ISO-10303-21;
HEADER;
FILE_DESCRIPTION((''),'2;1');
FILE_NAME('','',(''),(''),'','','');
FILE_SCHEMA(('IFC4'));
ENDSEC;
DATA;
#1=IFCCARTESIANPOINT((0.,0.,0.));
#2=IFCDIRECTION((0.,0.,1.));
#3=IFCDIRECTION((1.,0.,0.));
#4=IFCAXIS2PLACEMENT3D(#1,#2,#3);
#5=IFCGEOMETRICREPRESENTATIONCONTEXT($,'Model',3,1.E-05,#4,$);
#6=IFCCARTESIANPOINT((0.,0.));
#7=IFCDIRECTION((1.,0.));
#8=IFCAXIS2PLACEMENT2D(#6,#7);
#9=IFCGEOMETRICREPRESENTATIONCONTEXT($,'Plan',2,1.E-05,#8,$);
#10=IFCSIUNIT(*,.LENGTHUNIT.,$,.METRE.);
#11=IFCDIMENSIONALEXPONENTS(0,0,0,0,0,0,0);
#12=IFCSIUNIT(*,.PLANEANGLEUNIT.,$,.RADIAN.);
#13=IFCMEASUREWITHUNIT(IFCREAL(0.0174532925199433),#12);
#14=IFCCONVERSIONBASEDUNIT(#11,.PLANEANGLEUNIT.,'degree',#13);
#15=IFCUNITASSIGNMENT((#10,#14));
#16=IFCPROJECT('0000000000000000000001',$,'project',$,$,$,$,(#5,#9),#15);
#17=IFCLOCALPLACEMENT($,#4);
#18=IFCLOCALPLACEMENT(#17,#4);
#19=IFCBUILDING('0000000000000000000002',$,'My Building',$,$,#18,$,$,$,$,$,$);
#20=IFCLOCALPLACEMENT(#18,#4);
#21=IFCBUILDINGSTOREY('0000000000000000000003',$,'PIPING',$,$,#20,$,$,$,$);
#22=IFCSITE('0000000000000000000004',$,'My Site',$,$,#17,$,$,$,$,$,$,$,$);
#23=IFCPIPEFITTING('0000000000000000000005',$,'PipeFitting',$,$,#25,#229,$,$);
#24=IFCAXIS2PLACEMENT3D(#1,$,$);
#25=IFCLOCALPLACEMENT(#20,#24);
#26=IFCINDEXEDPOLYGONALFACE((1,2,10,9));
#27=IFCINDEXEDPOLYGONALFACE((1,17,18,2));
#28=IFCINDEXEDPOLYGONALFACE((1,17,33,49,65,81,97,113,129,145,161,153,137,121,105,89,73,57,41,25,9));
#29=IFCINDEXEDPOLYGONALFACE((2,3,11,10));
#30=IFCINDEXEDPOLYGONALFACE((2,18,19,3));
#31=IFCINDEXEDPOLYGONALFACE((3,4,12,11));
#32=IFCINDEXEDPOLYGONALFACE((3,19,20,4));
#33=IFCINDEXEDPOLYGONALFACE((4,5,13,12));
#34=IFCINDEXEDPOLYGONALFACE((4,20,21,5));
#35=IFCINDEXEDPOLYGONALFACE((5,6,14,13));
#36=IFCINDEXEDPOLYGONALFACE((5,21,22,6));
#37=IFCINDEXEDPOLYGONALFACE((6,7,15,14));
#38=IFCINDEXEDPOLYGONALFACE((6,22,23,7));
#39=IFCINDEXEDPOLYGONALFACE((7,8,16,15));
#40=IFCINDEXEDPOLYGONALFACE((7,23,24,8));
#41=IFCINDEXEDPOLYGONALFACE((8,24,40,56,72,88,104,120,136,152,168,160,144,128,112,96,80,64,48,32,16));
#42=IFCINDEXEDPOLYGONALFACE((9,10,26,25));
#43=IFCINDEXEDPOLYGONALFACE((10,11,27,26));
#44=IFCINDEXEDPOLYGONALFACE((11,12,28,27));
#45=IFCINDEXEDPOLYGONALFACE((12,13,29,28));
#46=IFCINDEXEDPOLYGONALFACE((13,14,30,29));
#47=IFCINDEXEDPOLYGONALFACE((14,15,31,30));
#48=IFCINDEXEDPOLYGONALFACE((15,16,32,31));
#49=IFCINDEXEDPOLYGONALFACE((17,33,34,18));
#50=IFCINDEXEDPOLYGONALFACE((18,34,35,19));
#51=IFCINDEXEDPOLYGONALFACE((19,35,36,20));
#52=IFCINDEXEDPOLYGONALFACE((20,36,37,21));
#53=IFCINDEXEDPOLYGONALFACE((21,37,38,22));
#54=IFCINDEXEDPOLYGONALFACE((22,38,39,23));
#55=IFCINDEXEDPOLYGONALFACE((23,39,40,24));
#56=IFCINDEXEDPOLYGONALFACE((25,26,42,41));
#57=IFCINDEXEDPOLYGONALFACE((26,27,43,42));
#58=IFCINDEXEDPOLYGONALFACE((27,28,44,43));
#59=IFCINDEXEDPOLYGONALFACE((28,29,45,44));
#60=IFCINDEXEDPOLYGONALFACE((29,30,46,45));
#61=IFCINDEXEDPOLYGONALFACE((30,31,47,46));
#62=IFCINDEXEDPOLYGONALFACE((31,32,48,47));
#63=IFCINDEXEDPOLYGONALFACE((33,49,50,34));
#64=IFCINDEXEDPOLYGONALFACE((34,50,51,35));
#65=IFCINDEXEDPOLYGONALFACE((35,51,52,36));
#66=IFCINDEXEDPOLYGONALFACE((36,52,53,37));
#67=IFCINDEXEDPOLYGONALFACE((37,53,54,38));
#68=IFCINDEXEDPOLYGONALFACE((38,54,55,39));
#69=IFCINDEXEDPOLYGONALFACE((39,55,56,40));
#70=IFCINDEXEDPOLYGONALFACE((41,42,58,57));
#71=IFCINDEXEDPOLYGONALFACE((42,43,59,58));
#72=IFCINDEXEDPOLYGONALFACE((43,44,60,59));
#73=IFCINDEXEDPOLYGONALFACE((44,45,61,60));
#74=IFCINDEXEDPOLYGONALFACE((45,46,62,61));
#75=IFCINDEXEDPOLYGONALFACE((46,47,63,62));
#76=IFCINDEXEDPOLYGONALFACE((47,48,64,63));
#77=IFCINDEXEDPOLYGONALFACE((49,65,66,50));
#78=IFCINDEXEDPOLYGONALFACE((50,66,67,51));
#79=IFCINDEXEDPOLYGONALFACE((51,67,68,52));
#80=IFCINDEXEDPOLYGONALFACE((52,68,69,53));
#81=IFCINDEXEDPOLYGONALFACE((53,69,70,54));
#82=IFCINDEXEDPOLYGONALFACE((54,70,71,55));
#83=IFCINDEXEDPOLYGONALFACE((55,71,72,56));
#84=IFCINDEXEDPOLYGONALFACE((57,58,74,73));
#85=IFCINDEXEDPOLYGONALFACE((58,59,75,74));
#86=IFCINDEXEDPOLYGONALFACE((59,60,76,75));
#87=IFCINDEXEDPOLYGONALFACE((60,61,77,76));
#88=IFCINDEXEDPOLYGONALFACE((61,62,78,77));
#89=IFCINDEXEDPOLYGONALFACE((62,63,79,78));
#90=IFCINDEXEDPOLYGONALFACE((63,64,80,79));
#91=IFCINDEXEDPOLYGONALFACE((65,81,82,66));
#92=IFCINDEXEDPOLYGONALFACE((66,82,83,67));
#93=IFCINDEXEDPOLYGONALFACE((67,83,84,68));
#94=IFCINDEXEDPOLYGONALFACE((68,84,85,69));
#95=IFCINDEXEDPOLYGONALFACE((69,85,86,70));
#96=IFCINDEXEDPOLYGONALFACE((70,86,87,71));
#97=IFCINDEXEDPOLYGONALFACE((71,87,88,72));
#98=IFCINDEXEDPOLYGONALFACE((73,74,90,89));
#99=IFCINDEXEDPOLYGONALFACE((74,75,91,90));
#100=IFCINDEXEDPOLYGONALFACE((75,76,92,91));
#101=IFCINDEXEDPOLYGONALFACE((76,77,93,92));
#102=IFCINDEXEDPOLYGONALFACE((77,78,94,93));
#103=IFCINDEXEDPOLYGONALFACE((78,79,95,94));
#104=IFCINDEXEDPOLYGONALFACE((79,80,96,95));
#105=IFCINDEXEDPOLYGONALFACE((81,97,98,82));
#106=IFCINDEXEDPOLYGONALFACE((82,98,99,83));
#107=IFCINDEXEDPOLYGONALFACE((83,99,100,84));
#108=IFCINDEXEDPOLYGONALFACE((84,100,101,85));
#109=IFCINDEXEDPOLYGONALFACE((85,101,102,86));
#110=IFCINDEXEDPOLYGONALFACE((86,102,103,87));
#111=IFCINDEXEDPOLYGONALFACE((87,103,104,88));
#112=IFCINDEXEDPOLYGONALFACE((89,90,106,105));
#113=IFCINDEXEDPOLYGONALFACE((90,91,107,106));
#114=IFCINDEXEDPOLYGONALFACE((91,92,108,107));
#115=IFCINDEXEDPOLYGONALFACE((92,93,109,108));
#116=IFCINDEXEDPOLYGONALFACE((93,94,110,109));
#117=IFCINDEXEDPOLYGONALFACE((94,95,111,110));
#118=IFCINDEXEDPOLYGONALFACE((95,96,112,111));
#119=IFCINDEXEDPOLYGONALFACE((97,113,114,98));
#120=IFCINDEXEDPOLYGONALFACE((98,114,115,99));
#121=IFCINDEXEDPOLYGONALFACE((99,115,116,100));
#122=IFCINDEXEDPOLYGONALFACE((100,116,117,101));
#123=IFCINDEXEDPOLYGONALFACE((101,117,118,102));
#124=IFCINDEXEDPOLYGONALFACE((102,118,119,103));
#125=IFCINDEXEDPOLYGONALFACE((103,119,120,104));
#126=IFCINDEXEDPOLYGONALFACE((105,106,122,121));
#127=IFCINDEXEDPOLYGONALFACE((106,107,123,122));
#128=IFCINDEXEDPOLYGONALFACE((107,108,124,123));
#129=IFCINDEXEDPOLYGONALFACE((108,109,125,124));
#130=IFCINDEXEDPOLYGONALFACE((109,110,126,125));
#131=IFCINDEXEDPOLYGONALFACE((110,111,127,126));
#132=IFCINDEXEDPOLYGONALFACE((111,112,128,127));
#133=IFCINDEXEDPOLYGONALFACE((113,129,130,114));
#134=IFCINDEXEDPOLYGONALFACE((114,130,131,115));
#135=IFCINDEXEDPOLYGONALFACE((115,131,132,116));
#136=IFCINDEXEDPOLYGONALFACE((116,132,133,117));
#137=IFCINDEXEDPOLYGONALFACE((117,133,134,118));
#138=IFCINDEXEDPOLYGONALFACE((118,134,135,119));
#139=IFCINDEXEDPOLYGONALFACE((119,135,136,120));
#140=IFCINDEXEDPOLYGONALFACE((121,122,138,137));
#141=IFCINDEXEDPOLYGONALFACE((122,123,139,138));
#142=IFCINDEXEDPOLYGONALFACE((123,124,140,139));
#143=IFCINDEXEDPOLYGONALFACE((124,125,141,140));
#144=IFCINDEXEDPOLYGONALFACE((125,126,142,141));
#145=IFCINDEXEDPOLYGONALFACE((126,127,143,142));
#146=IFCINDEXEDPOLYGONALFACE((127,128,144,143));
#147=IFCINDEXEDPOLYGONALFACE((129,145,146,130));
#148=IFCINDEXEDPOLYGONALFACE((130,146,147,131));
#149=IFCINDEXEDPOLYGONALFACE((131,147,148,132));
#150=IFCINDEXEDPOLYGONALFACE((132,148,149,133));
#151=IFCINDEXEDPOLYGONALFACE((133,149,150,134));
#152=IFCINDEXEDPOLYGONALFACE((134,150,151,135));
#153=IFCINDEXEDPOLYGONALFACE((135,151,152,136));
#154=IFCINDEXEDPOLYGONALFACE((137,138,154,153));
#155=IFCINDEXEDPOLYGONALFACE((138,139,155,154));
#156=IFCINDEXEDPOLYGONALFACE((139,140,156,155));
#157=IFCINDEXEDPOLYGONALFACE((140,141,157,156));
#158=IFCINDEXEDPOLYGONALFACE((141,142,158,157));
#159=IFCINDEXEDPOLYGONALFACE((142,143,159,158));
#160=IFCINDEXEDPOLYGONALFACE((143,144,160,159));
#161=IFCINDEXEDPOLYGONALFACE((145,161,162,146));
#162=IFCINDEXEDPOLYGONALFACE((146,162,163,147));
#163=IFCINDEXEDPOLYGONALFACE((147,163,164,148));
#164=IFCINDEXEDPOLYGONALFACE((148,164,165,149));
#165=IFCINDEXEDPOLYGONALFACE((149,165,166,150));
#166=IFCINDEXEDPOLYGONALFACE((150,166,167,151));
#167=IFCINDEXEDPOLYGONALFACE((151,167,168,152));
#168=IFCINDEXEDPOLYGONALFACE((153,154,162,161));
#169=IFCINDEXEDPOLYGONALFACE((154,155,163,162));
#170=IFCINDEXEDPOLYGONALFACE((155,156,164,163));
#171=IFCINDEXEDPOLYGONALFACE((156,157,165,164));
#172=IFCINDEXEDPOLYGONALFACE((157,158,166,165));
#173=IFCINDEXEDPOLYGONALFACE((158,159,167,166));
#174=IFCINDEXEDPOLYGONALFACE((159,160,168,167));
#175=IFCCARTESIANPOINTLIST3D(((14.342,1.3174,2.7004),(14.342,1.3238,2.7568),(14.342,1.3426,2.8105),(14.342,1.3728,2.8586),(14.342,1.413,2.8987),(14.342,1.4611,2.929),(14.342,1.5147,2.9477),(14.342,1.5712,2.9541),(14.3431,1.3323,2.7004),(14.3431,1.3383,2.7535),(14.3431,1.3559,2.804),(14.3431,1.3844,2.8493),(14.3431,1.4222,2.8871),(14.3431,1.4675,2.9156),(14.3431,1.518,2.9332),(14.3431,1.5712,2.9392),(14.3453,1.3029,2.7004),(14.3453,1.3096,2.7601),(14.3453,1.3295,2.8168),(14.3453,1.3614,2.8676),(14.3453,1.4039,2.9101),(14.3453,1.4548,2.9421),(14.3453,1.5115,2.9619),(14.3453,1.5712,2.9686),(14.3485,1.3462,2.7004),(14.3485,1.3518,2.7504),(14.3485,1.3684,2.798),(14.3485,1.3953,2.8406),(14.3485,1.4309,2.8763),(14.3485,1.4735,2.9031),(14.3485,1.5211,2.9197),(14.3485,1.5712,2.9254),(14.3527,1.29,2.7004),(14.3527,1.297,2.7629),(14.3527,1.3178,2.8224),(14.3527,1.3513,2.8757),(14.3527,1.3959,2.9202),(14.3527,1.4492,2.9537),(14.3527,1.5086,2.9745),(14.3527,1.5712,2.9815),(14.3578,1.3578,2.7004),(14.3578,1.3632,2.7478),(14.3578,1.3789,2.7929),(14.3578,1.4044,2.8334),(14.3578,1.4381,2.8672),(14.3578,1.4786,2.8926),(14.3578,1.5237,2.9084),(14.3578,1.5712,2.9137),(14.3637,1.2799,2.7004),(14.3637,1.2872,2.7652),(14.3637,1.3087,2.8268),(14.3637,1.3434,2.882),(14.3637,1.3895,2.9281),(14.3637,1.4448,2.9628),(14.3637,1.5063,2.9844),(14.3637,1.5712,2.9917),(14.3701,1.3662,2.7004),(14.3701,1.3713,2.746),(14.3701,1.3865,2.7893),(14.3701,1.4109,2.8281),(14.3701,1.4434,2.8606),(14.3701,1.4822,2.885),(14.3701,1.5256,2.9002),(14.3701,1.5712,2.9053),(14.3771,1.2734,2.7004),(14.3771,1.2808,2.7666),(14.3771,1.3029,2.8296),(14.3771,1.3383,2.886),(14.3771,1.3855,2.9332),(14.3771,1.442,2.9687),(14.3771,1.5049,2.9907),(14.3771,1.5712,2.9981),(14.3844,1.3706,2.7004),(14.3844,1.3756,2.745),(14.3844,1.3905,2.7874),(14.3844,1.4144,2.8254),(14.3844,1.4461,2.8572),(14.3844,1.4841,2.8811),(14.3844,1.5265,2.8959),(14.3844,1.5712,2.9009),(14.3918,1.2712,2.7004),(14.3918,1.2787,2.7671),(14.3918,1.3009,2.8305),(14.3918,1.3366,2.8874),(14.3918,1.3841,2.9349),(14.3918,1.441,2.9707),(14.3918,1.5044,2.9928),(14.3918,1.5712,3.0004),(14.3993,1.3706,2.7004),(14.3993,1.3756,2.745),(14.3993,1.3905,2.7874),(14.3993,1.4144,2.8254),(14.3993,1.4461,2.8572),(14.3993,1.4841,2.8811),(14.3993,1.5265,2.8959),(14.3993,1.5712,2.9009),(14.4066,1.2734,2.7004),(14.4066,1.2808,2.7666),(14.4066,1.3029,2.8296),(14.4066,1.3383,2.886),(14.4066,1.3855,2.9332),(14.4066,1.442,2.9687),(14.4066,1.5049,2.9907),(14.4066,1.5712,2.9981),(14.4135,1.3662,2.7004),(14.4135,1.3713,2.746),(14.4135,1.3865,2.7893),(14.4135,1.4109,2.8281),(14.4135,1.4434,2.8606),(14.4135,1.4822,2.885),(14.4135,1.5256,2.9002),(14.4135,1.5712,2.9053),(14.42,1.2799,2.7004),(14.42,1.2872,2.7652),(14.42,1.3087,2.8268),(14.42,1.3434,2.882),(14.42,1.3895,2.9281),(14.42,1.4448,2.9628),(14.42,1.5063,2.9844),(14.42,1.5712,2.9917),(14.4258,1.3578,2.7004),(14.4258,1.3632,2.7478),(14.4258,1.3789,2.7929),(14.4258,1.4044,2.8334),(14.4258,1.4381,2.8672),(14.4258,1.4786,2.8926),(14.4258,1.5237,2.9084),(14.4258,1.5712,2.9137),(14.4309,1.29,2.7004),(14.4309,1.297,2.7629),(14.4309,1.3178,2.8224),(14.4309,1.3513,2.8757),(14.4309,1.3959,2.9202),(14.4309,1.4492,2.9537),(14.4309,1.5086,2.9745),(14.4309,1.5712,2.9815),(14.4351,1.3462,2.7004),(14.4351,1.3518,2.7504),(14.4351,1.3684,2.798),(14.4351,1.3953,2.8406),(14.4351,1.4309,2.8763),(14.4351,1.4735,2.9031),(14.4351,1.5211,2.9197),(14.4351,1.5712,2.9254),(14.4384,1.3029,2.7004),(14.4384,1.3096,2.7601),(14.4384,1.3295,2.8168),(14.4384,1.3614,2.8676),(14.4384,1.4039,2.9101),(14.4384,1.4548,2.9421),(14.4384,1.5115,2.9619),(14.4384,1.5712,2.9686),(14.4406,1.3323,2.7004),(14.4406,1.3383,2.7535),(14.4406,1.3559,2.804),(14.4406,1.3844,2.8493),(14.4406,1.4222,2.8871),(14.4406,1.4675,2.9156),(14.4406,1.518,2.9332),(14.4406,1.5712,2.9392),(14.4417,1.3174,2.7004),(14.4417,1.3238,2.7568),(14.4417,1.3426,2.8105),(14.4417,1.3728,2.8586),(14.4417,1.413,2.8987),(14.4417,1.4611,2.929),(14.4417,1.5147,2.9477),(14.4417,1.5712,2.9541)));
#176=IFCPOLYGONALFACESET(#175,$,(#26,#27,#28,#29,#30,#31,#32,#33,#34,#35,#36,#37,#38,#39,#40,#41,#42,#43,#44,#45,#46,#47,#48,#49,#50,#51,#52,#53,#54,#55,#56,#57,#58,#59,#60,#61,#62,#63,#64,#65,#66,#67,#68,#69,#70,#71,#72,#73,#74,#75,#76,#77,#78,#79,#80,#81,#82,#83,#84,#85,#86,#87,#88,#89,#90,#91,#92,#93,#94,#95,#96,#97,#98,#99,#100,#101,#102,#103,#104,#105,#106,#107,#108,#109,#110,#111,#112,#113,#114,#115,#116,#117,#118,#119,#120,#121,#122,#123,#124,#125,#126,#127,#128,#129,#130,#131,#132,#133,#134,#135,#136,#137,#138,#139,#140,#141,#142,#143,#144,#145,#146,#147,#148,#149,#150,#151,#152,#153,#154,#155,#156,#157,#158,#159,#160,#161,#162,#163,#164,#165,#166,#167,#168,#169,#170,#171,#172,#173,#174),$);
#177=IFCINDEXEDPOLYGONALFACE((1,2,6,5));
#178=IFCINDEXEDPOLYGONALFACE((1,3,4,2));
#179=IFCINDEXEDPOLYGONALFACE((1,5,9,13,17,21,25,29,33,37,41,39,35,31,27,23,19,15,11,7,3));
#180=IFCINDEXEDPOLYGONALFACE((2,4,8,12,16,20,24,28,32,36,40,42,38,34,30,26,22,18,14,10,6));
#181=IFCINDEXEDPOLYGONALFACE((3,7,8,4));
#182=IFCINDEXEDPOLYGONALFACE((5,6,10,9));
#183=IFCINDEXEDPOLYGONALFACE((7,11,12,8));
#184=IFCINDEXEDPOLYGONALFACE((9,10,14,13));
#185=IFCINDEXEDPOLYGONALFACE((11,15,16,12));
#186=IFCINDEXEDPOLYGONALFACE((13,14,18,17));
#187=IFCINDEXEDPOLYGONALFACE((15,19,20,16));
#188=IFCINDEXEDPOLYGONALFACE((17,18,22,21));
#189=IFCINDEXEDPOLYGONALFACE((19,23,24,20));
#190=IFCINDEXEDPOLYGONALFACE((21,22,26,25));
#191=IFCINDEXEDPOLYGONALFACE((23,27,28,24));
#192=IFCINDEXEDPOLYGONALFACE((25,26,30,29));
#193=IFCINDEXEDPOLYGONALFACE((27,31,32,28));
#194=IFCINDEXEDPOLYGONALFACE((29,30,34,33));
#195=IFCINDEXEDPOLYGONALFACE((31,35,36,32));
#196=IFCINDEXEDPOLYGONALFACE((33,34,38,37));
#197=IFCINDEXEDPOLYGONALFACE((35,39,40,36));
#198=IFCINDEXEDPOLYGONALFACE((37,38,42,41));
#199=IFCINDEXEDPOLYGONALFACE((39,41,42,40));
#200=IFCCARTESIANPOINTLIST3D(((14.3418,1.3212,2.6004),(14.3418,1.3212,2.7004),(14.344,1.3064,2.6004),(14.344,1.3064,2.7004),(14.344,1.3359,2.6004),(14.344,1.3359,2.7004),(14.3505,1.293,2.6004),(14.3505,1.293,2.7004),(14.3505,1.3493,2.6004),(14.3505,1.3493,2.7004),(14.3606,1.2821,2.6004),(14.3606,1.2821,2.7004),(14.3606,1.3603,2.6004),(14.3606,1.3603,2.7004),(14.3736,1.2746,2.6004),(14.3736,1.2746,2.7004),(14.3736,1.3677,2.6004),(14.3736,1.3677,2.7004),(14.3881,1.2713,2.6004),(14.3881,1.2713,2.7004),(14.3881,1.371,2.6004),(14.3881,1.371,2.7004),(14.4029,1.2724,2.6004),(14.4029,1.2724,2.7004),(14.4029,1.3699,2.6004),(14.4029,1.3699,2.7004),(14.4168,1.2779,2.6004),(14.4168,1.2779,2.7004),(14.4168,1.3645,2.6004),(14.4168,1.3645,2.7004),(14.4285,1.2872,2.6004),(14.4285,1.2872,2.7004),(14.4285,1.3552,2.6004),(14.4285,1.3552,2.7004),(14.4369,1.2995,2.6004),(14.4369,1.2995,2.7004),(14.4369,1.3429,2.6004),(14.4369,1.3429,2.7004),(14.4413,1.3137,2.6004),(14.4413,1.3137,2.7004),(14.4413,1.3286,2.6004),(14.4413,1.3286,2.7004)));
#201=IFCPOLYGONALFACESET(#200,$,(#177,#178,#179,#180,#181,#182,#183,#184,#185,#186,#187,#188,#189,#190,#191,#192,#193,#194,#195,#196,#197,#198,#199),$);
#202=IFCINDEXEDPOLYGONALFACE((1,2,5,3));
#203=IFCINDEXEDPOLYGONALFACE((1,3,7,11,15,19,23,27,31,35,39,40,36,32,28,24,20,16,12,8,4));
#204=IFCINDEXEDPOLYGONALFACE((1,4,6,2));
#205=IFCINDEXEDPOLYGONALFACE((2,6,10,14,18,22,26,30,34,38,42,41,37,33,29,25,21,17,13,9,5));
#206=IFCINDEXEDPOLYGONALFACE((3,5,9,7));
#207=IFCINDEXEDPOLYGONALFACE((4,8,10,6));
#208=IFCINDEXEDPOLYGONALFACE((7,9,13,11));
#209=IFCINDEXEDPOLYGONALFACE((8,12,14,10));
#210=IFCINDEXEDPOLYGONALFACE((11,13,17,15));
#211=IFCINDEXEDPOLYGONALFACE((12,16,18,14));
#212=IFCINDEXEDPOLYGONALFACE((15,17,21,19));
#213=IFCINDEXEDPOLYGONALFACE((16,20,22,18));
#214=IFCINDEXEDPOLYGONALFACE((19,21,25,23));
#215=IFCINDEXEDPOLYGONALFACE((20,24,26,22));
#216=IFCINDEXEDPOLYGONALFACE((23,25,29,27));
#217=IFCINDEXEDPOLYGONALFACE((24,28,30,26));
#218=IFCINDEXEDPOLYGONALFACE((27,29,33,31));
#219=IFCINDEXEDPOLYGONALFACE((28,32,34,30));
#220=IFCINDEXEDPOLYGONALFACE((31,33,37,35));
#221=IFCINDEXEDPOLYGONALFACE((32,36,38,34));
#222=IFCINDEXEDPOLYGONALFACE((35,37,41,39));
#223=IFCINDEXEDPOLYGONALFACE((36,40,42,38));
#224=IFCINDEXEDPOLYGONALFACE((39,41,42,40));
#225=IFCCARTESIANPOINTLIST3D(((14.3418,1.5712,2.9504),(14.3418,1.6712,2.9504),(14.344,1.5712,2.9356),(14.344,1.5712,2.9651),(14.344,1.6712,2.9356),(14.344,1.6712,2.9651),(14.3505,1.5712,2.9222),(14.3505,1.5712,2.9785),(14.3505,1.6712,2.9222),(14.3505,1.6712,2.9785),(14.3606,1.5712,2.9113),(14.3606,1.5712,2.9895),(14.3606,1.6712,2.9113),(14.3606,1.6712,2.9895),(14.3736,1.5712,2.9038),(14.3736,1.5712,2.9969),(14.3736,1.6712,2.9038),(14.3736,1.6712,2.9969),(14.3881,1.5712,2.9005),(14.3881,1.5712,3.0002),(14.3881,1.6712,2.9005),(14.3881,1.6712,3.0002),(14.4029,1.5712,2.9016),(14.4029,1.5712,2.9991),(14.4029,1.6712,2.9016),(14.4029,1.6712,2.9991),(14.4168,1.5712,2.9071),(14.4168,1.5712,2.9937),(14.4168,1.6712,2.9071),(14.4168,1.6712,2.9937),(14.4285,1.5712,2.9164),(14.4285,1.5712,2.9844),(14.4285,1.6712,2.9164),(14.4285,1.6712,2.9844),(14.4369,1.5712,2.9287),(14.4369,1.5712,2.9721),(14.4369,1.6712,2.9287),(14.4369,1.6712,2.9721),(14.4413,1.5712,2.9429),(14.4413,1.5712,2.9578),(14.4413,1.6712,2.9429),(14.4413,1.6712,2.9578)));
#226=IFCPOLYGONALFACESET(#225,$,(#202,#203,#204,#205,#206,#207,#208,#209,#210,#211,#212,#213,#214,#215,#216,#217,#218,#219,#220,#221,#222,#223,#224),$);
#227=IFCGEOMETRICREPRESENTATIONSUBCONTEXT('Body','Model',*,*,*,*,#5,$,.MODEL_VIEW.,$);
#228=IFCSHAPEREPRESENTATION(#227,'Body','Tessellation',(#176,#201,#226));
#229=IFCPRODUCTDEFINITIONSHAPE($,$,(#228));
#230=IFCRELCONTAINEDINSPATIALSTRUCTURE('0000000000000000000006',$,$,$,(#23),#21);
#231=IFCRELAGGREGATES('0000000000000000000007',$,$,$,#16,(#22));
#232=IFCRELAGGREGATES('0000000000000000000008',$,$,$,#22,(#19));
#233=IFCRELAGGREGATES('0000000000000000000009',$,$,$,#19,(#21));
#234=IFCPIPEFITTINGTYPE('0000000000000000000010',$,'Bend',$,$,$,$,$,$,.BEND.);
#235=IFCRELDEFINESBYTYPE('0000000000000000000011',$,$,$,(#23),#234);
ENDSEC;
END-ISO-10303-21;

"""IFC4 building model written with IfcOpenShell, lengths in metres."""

from ifc_helpers import new_model, entity, si_unit, converted_unit, frame, origin_with_axes, origin_2d_with_axis, place, context, subcontext, project, spatial, circle, extrude, source, transform, mapped, type_object, type_shapes, element, save


model = new_model("IFC4")

# Units and contexts
model_context = context("Model", 3, precision=1e-05, world=origin_with_axes())
plan_context = context("Plan", 2, precision=1e-05, world=origin_2d_with_axis())
body_context = subcontext(model_context, "Body", "Model", "MODEL_VIEW")
ifc_project = project(units=[si_unit("LENGTHUNIT", "METRE"), converted_unit("PLANEANGLEUNIT", "degree", entity("IfcReal", 0.0174532925199433), si_unit("PLANEANGLEUNIT", "RADIAN"), dimensions=[0, 0, 0, 0, 0, 0, 0])], contexts=[model_context, plan_context])

# Site, building, storey
site_placement = place(None, origin_with_axes())
site = spatial("IfcSite", under=ifc_project, at=site_placement, Name="My Site")
building_placement = place(site_placement, origin_with_axes())
building = spatial("IfcBuilding", under=site, at=building_placement, Name="My Building")
storey_placement = place(building_placement, origin_with_axes())
storey = spatial("IfcBuildingStorey", under=building, at=storey_placement, Name="PIPING")

# Pipe fitting
pipe_fitting_type_1 = type_object("IfcPipeFittingType", Name="Bend", PredefinedType="BEND")
shared_shape = source(origin_with_axes(), body_context, "Body", "SolidModel", [
    entity("IfcSweptDiskSolid", entity("IfcIndexedPolyCurve", entity("IfcCartesianPointList3D", [[0.0, 0.0, -0.1], [0.0, 0.0732, -0.2768], [0.0, 0.25, -0.35]]), [entity("IfcArcIndex", [1, 2, 3])]), 0.05),
    extrude(circle(Radius=0.05), origin_with_axes(), (0.0, 0.0, -1.0), 0.1),
    extrude(circle(Radius=0.05), frame((0.0, 0.25, -0.35), z_axis=(0.0, 1.0, 0.0), x_axis=(1.0, 0.0, 0.0)), (0.0, 0.0, 1.0), 0.1),
])
type_shapes(pipe_fitting_type_1, [shared_shape])
for number, where, z_axis, x_axis, name in (
    (1, (14.3918, 1.3212, 2.6004), (0.0, 0.0, -1.0), (-1.0, 0.0, 0.0), "PipeFitting"),
):
    element("IfcPipeFitting", number, at=place(storey_placement, frame(where, z_axis=z_axis, x_axis=x_axis)), inside=storey, type_object=pipe_fitting_type_1, Name=name, context=body_context, shape_type="MappedRepresentation", body=[
        mapped(shared_shape, transform((0.0, 0.0, 0.0), x_axis=(1.0, 0.0, 0.0), y_axis=(0.0, 1.0, 0.0), z_axis=(0.0, 0.0, 1.0), scale=1.0)),
    ])

save(model, "model.ifc")
